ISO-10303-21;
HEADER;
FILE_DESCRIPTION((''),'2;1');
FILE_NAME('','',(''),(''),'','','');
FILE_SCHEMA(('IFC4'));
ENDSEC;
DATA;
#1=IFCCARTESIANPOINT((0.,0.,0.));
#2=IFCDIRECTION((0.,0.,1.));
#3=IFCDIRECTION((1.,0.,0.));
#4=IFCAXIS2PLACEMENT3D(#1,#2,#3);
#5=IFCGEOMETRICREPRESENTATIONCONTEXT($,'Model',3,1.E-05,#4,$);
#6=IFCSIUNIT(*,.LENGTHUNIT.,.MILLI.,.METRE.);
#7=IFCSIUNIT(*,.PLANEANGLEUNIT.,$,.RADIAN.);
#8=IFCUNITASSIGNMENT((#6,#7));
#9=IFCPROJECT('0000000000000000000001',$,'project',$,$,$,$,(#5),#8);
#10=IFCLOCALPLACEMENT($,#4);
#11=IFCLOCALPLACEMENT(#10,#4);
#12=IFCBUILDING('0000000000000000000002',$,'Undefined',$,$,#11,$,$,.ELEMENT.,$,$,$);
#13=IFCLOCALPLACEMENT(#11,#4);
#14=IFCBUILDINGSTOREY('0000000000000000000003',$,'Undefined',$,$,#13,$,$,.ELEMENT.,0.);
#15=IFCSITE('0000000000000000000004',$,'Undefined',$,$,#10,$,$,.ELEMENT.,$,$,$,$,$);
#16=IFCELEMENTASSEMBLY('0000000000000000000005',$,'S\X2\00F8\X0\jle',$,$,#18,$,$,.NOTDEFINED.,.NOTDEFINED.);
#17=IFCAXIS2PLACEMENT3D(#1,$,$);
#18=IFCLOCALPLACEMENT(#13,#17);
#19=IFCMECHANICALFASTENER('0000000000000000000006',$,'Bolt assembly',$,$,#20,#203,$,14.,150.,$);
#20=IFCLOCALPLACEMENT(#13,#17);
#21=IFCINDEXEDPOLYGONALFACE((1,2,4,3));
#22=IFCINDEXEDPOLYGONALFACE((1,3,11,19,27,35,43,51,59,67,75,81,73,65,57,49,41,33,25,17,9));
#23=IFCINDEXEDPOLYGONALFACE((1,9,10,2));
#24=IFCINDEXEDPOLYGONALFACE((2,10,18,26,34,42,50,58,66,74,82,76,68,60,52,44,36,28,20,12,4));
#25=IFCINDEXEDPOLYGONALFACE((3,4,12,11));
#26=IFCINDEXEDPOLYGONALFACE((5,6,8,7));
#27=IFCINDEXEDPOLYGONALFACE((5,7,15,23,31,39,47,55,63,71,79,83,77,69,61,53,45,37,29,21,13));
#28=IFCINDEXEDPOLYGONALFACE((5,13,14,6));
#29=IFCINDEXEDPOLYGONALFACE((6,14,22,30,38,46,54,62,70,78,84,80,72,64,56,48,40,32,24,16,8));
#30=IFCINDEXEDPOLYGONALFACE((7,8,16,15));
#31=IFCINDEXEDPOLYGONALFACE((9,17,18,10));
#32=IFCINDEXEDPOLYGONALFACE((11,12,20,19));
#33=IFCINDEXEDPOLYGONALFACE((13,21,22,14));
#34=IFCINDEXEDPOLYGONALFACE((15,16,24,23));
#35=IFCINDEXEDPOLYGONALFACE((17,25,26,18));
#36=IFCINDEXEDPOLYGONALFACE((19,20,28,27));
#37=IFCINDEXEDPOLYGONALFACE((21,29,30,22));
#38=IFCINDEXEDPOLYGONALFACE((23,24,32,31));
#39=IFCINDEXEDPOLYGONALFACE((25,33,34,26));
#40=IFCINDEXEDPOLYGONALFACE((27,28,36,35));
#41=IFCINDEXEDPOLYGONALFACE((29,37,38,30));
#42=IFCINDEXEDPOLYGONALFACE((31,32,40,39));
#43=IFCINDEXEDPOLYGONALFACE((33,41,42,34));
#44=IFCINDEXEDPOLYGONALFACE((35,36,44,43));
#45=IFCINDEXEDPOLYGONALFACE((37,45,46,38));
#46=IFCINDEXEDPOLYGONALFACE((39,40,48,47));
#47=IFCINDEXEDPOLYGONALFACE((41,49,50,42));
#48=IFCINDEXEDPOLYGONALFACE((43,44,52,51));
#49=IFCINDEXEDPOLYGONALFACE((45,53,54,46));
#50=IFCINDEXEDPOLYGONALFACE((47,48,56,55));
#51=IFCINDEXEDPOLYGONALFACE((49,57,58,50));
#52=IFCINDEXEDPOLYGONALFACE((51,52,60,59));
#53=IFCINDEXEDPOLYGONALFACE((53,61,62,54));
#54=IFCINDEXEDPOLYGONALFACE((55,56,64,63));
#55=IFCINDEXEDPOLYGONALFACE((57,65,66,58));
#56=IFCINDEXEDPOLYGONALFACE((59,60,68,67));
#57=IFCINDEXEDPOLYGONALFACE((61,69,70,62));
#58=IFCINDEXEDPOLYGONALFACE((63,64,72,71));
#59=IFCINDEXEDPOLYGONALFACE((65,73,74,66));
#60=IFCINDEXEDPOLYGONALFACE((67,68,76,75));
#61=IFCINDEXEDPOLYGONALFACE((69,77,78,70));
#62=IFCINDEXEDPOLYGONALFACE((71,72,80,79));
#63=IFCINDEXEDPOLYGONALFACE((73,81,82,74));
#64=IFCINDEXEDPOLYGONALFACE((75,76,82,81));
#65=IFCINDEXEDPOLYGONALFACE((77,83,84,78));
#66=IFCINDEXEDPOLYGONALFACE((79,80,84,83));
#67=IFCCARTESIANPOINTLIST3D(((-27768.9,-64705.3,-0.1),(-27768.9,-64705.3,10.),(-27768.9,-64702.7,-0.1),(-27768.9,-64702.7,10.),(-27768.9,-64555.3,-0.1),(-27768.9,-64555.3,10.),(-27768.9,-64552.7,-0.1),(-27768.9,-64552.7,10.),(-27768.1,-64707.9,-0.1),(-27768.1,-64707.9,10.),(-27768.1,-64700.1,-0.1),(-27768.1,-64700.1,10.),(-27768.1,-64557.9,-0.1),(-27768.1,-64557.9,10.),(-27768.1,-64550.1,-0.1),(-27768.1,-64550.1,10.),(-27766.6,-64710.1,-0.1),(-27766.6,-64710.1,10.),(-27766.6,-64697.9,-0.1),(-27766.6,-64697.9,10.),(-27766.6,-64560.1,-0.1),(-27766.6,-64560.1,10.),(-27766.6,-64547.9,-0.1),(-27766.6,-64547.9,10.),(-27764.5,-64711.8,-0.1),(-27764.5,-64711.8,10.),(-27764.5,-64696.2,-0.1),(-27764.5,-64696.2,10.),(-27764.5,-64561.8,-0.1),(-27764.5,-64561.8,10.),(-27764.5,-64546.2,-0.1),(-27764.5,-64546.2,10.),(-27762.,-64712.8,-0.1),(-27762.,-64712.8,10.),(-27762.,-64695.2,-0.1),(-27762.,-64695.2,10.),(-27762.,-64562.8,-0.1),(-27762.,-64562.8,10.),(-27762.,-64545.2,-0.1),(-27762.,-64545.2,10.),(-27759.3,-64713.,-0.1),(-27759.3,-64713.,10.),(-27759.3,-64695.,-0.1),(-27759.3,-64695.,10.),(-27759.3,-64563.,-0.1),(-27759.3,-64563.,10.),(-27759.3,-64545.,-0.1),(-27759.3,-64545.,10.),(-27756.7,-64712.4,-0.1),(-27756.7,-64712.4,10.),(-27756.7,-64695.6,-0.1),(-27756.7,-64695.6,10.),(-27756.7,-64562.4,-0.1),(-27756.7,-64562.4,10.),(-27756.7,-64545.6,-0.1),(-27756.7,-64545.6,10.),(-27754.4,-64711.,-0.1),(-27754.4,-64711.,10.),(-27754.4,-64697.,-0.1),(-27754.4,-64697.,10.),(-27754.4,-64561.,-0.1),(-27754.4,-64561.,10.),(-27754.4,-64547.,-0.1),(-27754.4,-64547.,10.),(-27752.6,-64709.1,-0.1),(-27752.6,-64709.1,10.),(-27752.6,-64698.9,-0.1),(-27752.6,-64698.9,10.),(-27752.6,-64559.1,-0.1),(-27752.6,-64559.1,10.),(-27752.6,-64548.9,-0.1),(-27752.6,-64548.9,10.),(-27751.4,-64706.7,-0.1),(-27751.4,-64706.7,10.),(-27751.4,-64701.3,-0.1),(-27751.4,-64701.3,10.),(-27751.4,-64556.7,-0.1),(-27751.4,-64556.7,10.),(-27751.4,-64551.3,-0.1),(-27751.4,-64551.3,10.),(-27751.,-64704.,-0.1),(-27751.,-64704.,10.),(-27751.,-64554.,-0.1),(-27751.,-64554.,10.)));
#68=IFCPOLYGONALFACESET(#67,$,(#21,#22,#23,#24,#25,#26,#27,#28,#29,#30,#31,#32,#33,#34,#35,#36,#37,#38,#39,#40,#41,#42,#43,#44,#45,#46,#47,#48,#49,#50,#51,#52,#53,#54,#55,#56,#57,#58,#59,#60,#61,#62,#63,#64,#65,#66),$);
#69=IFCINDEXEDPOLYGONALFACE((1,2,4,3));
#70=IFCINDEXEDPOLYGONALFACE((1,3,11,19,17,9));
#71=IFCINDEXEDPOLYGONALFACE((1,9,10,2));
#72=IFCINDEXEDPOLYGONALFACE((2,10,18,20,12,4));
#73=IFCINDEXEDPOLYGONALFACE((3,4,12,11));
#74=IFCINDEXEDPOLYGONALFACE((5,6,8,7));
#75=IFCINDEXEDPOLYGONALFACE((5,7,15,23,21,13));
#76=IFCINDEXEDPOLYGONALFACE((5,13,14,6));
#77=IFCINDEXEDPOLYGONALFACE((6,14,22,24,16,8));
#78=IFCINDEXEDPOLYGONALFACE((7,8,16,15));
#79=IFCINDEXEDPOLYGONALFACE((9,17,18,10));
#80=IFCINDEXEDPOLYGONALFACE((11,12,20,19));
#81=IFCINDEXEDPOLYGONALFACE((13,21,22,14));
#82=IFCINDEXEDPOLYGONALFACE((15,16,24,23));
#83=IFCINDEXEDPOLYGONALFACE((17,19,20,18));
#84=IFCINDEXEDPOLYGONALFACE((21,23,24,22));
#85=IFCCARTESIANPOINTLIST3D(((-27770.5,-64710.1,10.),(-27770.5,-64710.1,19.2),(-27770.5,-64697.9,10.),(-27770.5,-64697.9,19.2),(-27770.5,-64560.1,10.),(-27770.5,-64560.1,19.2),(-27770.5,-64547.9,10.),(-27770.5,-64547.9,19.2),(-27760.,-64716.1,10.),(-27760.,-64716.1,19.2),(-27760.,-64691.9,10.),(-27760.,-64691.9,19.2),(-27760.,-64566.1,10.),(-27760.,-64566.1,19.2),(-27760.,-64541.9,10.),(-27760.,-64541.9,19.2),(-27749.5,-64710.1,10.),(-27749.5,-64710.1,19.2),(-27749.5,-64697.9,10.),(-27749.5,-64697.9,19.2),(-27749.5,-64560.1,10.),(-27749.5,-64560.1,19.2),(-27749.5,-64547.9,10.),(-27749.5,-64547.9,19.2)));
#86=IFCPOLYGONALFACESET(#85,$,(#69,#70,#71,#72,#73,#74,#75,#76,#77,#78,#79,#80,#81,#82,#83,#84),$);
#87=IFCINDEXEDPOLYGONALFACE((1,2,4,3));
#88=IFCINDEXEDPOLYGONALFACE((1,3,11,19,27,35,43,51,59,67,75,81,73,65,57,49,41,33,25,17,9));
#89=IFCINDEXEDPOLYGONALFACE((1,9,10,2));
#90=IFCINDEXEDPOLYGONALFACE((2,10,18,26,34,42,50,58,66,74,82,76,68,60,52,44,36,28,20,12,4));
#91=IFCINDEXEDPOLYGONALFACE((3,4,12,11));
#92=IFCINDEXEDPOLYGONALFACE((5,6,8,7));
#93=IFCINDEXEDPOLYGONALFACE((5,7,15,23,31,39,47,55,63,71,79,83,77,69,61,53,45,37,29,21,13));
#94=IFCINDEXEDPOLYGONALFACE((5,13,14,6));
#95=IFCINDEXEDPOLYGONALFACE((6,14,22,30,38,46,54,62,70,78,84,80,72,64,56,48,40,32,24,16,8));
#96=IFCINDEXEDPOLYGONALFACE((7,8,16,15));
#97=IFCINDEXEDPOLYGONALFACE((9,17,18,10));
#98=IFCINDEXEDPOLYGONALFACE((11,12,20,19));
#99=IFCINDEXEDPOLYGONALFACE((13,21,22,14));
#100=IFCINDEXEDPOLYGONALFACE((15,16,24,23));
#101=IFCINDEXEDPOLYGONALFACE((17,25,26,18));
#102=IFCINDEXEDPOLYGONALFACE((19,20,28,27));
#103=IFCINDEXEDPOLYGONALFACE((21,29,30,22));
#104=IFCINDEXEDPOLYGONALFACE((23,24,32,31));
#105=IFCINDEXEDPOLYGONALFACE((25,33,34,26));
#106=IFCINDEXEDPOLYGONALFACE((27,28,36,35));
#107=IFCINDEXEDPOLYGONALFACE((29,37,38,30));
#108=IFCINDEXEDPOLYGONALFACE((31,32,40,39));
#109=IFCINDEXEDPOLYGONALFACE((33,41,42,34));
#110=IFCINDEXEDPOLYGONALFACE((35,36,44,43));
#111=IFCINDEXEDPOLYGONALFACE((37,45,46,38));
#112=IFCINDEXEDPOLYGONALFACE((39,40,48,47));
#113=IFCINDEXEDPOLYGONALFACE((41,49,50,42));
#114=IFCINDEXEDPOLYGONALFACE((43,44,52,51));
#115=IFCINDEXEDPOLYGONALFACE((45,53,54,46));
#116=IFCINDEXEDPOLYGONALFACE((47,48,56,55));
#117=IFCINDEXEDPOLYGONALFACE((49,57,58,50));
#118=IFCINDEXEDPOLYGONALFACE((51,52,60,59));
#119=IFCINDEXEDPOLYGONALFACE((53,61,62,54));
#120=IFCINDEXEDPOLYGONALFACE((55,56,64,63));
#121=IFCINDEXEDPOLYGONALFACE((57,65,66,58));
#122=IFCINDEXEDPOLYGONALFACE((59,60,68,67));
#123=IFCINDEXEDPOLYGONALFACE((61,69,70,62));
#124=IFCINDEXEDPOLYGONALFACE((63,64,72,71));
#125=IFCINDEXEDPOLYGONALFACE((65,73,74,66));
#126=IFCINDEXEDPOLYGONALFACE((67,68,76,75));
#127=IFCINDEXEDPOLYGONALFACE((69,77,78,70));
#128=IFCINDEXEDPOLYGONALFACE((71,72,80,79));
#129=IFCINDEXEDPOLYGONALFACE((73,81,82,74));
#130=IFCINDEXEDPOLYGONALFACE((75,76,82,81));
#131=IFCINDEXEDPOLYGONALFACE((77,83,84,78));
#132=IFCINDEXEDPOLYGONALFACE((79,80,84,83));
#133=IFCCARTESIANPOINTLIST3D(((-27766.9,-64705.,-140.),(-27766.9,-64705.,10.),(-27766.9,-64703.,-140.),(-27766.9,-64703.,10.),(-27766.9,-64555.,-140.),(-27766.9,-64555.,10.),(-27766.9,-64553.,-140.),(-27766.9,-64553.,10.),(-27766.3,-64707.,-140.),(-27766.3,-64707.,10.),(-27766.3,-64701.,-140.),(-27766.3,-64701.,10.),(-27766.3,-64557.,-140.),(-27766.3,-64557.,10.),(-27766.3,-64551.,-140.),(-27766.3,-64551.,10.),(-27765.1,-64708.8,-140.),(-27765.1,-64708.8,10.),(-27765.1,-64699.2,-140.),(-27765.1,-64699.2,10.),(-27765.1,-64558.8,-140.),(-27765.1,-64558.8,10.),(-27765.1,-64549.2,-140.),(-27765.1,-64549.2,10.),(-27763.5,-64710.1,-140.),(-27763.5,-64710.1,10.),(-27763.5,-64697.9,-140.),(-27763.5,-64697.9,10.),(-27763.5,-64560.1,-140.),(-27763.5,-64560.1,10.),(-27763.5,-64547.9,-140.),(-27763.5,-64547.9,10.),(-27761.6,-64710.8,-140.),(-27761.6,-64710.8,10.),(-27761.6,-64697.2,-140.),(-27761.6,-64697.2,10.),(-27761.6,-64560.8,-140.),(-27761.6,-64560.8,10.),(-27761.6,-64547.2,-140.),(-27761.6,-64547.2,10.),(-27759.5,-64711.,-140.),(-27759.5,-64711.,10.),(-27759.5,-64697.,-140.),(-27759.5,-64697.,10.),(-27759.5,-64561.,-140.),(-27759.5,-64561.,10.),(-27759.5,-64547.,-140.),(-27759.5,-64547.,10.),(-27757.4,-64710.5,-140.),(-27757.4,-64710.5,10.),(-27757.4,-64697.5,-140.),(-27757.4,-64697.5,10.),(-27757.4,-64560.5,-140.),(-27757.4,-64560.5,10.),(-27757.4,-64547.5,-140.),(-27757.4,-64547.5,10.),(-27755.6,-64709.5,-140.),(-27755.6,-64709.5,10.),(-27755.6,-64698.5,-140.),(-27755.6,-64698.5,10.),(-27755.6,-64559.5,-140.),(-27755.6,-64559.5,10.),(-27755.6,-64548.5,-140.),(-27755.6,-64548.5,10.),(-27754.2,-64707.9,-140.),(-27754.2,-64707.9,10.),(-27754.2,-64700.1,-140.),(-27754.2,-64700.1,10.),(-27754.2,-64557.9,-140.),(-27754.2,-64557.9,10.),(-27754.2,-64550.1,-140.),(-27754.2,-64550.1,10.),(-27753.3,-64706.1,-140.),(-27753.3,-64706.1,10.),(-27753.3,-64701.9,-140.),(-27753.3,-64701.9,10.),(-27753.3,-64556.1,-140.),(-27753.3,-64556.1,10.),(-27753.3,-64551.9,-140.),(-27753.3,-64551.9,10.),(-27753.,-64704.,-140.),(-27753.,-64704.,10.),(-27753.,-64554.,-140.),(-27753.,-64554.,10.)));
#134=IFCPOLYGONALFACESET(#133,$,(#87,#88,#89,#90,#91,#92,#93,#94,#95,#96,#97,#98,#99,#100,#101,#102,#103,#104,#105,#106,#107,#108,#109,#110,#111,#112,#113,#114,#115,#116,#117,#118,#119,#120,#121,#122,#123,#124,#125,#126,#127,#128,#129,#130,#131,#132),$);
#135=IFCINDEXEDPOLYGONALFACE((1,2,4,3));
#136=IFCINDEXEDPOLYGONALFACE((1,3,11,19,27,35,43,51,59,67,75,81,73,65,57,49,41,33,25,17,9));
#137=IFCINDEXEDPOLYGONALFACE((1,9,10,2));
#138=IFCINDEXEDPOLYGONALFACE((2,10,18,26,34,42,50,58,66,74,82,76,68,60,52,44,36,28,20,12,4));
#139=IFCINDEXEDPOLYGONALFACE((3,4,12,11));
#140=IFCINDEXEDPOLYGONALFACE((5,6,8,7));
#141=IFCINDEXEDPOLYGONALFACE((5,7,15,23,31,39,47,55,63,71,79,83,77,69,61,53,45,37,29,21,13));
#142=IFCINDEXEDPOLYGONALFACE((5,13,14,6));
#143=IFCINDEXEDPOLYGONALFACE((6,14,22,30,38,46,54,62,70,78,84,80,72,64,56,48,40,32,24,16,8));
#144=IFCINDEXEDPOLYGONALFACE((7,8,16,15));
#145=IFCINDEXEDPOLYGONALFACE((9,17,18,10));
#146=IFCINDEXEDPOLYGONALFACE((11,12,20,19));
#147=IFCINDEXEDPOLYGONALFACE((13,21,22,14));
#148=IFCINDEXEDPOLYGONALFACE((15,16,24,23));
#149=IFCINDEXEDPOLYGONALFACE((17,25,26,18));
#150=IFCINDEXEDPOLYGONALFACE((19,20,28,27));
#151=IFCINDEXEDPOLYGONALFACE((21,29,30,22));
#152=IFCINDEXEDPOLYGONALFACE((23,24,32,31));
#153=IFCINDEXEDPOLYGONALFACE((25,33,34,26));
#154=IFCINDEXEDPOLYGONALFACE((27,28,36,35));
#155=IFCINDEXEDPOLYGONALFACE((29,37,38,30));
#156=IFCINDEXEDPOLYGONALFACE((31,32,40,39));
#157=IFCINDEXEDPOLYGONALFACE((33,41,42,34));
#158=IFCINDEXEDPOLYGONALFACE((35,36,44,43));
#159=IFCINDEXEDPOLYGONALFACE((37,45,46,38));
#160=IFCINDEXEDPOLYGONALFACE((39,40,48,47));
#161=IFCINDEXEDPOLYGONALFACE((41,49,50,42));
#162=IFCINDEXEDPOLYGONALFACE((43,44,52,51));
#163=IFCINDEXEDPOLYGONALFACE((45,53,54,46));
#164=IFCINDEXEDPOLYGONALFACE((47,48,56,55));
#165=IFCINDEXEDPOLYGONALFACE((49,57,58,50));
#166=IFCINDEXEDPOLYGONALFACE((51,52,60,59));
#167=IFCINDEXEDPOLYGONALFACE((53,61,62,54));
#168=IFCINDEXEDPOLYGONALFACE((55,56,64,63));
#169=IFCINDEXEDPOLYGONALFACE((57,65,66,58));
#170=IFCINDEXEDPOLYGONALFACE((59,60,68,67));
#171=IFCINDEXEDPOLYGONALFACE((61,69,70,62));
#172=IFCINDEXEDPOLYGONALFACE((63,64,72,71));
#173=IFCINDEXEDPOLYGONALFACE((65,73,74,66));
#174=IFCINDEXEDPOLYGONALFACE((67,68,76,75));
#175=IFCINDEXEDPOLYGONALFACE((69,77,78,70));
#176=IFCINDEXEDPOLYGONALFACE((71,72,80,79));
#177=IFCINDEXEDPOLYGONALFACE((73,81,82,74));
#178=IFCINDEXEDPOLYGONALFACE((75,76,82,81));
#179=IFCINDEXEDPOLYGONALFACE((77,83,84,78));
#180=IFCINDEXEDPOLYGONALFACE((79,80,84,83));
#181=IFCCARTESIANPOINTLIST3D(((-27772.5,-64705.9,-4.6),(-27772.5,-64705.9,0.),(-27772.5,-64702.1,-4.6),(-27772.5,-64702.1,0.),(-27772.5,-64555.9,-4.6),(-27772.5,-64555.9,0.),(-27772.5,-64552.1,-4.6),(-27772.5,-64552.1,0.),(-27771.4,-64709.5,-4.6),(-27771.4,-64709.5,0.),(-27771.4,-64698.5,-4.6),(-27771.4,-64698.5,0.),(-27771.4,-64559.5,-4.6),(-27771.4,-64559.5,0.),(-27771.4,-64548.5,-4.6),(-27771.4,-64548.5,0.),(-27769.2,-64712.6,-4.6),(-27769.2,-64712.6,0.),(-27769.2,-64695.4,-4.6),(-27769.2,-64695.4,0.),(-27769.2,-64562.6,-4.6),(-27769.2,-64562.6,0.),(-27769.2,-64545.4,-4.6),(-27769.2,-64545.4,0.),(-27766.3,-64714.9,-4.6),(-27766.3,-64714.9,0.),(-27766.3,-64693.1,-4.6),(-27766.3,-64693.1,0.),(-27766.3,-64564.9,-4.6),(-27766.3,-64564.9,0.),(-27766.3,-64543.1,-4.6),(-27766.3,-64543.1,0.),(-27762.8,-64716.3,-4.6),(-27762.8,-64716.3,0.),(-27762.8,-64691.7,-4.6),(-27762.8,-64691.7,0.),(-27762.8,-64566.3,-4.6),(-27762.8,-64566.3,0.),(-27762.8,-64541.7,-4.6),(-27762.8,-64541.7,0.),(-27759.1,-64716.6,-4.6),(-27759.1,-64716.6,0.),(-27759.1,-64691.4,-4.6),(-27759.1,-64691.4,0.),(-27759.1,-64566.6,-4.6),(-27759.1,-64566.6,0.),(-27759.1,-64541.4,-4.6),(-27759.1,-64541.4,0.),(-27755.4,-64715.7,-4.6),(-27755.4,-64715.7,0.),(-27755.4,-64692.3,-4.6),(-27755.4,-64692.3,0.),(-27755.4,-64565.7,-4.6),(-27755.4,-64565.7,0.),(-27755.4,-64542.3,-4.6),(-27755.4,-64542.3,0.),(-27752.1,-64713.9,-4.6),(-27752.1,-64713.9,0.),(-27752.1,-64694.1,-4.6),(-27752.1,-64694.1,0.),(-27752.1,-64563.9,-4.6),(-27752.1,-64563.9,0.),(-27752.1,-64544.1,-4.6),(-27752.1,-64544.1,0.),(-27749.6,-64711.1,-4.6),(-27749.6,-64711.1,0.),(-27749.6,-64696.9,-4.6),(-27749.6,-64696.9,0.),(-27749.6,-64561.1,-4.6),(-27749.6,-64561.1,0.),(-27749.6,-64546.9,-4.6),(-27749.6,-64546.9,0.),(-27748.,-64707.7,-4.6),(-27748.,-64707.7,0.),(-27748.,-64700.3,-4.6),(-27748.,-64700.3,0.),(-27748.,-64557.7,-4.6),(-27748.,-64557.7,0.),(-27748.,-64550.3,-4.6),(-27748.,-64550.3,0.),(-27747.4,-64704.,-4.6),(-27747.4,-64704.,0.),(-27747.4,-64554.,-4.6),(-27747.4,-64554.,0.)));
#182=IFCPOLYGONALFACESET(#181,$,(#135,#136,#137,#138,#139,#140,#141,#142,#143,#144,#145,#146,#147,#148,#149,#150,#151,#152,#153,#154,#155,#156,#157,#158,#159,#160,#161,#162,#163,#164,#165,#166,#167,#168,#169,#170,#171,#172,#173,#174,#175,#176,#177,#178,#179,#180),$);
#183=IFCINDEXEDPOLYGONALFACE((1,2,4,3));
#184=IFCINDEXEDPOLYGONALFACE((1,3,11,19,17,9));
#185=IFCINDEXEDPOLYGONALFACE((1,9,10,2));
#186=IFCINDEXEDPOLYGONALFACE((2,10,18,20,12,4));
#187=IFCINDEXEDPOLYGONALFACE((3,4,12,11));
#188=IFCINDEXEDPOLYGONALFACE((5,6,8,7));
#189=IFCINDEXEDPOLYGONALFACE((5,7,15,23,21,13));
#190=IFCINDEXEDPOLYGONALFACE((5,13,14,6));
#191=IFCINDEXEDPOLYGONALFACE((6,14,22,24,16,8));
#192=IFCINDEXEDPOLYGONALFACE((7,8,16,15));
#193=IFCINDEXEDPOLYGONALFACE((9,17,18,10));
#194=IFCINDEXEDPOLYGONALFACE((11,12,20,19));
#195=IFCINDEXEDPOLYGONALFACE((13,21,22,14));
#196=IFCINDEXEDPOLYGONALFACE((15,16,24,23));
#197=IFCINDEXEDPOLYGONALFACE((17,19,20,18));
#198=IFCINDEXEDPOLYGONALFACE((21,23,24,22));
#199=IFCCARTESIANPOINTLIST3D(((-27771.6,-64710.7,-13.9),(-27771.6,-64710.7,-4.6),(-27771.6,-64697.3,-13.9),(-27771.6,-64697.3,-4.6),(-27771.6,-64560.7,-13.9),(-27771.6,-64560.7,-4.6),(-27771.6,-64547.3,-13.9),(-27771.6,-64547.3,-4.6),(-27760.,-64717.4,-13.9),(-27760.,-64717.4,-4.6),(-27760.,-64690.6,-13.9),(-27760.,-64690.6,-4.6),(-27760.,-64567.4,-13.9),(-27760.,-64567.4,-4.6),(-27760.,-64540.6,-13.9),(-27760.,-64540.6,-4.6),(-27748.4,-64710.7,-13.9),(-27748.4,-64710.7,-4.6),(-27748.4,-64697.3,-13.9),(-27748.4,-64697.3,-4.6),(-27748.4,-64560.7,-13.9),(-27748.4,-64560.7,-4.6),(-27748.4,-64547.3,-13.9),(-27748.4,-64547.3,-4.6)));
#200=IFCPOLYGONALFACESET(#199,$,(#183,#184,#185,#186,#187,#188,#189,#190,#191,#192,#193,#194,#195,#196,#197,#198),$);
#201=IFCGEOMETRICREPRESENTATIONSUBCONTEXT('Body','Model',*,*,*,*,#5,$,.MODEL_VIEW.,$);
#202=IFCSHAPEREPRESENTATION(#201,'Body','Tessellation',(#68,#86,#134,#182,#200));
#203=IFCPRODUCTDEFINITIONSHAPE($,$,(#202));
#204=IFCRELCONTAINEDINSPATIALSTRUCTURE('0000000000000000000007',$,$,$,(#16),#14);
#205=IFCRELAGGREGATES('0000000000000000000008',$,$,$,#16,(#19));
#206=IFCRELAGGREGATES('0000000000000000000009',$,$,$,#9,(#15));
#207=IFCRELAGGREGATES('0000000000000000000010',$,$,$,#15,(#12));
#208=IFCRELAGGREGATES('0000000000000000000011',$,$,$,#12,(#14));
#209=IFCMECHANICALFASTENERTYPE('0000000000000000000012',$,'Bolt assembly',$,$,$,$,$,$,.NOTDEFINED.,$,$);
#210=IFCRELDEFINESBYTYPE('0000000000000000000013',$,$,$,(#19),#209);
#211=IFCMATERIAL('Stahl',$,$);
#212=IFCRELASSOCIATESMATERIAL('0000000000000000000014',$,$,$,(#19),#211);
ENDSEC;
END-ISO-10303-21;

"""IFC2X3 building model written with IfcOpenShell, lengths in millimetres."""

from ifc_helpers import new_model, si_unit, frame, origin_with_axes, origin_2d_with_axis, place, context, subcontext, project, spatial, polyline, circle, outline, extrude, source, transform, mapped, material, type_object, element, aggregate, save


model = new_model("IFC2X3")

# Units and contexts
model_context = context("Model", 3, precision=1e-05, world=origin_with_axes())
body_context = subcontext(model_context, "Body", "Model", "MODEL_VIEW")
ifc_project = project(units=[si_unit("LENGTHUNIT", "METRE", prefix="MILLI"), si_unit("PLANEANGLEUNIT", "RADIAN")], contexts=[model_context])

# Site, building, storey
site_placement = place(None, origin_with_axes())
site = spatial("IfcSite", under=ifc_project, at=site_placement, Name="Undefined", CompositionType="ELEMENT")
building_placement = place(site_placement, origin_with_axes())
building = spatial("IfcBuilding", under=site, at=building_placement, Name="Undefined", CompositionType="ELEMENT")
storey_placement = place(building_placement, origin_with_axes())
storey = spatial("IfcBuildingStorey", under=building, at=storey_placement, Name="Undefined", CompositionType="ELEMENT", Elevation=0.0)

# Shared definitions
mechanical_fastener_type = type_object("IfcMechanicalFastenerType", Name="Bolt assembly")

# Element assembly
assembly_1_placement = place(storey_placement, origin_with_axes())
assembly_1 = element("IfcElementAssembly", 1, at=assembly_1_placement, inside=storey, Name="Søjle", AssemblyPlace="NOTDEFINED", PredefinedType="NOTDEFINED")

# Mechanical fastener
ifc_material_1 = material(Name="Stahl")
shared_shape_1 = source(origin_with_axes(), body_context, "Body", "SweptSolid", [
    extrude(circle(Radius=9.0, at=origin_2d_with_axis()), frame((0.0, 0.0, 0.0), z_axis=(0.0, 1.0, 0.0), x_axis=(1.0, 0.0, 0.0)), (0.0, 0.0, 1.0), 10.1),
    extrude(outline(polyline([(10.5, -6.1), (10.5, 6.1), (0.0, 12.1), (-10.5, 6.1), (-10.5, -6.1), (0.0, -12.1), (10.5, -6.1)])), frame((0.0, -9.2, 0.0), z_axis=(0.0, 1.0, 0.0), x_axis=(1.0, 0.0, 0.0)), (0.0, 0.0, 1.0), 9.2),
    extrude(circle(Radius=7.0, at=origin_2d_with_axis()), frame((0.0, 0.0, 0.0), z_axis=(0.0, 1.0, 0.0), x_axis=(1.0, 0.0, 0.0)), (0.0, 0.0, 1.0), 150.0),
    extrude(circle(Radius=12.6, at=origin_2d_with_axis()), frame((0.0, 10.0, 0.0), z_axis=(0.0, 1.0, 0.0), x_axis=(1.0, 0.0, 0.0)), (0.0, 0.0, 1.0), 4.6),
    extrude(outline(polyline([(11.6, -6.7), (11.6, 6.7), (0.0, 13.4), (-11.6, 6.7), (-11.6, -6.7), (0.0, -13.4), (11.6, -6.7)])), frame((0.0, 14.6, 0.0), z_axis=(0.0, 1.0, 0.0), x_axis=(1.0, 0.0, 0.0)), (0.0, 0.0, 1.0), 9.2),
])
mechanical_fastener_1_placement = place(assembly_1_placement, frame((-27760.0, -64629.0, 10.0), z_axis=(0.0, 1.0, 0.0), x_axis=(1.0, 0.0, 0.0)))
mechanical_fastener_1 = element("IfcMechanicalFastener", 2, at=mechanical_fastener_1_placement, type_object=mechanical_fastener_type, material=ifc_material_1, Name="Bolt assembly", NominalDiameter=14.0, NominalLength=150.0, context=body_context, shape_type="MappedRepresentation", body=[
    mapped(shared_shape_1, transform((0.0, 0.0, -75.0))),
    mapped(shared_shape_1, transform((0.0, 0.0, 75.0))),
])
aggregate(assembly_1, [mechanical_fastener_1])

save(model, "model.ifc")
